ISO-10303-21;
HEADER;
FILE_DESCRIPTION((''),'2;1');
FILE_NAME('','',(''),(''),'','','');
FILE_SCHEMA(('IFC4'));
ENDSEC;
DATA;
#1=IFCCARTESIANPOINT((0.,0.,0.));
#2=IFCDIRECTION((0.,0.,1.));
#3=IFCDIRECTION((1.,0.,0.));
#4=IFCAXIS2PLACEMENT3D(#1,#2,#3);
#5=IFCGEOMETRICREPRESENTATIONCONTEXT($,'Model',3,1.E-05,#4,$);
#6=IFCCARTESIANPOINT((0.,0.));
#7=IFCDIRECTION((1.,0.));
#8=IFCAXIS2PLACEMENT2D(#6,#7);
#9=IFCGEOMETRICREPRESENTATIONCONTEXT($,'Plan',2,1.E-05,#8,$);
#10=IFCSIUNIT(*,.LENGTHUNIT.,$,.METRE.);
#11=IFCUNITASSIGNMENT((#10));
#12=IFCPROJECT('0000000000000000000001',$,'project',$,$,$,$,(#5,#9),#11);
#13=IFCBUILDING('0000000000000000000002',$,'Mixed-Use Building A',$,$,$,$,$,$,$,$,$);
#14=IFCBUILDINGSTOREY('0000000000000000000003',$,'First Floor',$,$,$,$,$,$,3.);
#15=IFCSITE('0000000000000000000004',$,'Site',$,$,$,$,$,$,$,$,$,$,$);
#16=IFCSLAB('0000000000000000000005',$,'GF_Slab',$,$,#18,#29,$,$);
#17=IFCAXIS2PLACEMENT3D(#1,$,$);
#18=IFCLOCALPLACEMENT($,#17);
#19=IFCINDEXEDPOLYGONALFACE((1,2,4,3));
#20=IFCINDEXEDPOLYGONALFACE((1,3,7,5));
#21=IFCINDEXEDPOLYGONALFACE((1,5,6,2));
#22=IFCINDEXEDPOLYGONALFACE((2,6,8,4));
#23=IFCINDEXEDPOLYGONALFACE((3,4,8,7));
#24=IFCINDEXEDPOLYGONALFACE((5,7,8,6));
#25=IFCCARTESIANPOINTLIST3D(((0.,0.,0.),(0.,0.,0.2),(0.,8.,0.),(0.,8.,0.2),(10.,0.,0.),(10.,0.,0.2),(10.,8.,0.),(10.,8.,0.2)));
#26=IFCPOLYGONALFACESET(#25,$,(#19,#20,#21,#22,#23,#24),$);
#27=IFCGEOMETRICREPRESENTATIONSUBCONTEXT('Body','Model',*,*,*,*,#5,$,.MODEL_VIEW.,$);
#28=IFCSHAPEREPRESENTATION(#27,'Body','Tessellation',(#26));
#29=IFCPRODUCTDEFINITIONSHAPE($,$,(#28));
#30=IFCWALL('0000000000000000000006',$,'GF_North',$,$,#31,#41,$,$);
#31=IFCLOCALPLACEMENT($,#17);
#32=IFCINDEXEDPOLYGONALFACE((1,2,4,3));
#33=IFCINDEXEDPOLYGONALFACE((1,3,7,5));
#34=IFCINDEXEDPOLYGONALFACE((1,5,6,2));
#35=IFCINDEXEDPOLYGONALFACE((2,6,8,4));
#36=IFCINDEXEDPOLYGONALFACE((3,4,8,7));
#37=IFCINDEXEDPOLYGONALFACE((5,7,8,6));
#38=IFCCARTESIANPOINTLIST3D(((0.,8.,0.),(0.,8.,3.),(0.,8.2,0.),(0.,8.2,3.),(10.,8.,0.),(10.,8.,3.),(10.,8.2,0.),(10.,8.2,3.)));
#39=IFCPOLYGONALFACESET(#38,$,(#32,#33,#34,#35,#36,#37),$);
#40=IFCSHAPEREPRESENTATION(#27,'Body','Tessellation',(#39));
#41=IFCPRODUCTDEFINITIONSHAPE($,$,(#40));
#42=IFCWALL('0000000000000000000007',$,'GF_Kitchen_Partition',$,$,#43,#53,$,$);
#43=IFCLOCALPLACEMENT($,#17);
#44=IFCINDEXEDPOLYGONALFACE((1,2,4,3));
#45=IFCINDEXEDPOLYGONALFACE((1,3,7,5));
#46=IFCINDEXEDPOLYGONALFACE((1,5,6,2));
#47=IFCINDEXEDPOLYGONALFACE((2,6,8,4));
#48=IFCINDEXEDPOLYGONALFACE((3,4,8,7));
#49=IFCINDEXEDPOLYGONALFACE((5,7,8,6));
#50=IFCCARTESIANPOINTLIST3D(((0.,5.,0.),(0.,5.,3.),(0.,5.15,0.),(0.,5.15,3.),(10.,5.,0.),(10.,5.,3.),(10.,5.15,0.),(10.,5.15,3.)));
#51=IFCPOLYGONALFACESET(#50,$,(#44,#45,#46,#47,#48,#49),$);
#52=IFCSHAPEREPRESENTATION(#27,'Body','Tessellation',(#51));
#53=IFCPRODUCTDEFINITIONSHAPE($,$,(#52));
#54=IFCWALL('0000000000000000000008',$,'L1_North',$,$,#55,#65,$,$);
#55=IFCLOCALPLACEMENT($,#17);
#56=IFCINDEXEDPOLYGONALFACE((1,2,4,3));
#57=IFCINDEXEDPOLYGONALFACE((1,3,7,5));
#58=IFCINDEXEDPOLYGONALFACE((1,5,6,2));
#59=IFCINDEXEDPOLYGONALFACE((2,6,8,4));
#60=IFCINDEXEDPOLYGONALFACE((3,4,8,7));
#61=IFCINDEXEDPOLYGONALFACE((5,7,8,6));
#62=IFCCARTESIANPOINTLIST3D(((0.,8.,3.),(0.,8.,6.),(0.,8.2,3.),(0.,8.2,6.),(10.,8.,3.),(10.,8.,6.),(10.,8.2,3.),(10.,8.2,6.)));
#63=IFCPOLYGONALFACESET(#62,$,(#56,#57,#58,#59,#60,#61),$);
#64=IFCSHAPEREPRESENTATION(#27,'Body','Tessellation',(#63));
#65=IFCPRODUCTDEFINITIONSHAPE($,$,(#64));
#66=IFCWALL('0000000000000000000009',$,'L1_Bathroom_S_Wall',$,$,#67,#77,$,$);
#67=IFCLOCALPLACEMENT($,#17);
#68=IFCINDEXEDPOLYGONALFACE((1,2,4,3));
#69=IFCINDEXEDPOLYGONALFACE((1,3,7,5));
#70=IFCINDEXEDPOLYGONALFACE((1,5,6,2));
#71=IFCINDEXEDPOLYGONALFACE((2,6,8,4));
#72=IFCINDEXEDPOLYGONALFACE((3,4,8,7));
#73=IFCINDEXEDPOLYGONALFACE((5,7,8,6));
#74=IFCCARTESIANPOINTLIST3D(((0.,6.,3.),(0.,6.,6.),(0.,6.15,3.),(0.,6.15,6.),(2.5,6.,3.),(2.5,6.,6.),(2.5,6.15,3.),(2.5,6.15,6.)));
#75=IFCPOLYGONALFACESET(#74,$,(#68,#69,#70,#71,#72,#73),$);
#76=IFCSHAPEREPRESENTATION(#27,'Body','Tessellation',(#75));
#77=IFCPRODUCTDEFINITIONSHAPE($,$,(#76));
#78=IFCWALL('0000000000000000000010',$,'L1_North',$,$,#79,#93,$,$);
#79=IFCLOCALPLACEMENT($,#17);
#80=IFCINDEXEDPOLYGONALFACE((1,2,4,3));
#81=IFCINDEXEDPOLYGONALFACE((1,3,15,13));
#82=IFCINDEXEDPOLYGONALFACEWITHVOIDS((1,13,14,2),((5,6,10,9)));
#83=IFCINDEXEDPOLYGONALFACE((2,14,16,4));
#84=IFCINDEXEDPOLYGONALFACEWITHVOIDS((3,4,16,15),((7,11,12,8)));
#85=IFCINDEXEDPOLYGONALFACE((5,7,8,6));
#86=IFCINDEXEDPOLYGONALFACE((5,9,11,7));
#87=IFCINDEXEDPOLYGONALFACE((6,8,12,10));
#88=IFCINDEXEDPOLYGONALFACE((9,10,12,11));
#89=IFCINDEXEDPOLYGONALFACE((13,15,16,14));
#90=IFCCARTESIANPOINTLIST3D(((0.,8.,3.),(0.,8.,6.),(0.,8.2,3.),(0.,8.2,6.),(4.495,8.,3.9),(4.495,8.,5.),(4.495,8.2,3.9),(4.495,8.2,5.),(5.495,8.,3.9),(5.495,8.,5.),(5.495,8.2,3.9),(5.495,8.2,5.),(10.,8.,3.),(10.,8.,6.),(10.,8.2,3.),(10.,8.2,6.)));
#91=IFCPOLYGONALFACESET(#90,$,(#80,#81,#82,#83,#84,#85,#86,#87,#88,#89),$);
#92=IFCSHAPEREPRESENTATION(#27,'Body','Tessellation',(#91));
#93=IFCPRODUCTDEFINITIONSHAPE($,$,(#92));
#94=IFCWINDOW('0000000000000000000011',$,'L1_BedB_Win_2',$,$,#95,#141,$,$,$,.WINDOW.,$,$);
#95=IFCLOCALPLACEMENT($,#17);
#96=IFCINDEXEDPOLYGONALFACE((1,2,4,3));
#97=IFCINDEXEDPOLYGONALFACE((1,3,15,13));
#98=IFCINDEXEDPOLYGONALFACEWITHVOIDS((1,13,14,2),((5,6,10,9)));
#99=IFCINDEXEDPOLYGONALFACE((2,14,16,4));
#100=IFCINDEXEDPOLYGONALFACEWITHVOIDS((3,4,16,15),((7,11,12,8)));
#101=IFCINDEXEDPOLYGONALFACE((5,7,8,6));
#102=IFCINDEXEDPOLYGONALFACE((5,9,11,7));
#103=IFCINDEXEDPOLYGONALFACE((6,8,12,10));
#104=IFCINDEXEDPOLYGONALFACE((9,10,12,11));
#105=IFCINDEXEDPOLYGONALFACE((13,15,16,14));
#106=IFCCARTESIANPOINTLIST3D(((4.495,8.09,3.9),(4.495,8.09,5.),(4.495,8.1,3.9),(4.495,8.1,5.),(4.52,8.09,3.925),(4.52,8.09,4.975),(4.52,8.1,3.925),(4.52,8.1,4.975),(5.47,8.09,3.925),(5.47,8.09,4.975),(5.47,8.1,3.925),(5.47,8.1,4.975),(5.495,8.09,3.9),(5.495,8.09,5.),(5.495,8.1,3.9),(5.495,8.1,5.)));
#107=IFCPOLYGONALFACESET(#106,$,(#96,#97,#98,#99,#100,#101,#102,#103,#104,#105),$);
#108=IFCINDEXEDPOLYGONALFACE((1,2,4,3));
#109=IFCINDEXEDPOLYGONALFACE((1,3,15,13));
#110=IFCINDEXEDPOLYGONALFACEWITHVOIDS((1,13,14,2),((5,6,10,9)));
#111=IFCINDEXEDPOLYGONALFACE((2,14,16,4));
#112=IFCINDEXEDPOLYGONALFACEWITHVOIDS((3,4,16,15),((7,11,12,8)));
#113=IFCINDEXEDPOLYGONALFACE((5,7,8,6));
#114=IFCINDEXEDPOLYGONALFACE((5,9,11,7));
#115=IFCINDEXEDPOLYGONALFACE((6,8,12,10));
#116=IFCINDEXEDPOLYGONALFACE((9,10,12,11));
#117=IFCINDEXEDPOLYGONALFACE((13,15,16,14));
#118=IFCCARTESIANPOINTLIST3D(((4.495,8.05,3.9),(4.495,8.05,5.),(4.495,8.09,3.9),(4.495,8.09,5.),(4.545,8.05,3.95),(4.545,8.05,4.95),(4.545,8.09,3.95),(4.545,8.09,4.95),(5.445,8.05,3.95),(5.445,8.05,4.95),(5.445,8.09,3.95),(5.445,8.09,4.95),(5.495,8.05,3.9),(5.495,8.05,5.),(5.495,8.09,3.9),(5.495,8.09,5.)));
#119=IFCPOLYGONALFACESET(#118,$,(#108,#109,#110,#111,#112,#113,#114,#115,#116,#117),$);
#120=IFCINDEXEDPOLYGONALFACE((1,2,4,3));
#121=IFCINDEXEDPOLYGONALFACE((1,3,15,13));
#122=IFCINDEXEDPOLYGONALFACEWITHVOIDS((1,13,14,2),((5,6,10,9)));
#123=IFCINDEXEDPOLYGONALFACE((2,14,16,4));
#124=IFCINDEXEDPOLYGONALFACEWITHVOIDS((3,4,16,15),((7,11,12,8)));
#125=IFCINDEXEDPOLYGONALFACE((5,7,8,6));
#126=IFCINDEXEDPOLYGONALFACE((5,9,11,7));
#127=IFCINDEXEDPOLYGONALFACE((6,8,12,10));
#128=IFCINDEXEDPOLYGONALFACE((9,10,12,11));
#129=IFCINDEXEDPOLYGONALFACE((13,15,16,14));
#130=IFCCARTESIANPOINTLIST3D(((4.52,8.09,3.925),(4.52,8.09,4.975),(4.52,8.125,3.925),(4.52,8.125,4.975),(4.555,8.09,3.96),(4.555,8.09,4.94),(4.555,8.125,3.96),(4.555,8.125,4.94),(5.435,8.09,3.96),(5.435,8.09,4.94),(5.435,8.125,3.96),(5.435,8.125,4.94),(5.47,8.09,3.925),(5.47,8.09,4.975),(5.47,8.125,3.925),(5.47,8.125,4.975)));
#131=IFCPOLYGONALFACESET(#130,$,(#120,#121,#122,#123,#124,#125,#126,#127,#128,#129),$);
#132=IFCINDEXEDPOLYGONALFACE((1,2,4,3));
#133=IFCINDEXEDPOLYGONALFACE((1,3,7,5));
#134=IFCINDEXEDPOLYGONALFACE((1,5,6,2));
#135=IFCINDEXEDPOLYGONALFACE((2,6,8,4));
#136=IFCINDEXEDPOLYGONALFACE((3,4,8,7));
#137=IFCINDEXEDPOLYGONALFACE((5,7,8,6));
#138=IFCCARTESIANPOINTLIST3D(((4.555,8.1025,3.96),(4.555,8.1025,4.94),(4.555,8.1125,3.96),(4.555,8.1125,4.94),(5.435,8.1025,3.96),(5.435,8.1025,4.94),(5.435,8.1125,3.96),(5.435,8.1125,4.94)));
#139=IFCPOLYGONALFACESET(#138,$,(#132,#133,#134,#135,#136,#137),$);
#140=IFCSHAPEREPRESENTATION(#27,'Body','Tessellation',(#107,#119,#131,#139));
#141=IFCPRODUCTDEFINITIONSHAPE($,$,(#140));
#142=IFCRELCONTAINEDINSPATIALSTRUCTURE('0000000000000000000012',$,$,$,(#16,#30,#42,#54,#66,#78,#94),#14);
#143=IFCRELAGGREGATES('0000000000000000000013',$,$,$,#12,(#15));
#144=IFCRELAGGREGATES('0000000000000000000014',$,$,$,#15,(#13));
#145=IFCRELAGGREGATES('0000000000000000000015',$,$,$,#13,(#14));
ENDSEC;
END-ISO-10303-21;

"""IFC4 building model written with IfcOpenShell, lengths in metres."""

from ifc_helpers import new_model, si_unit, frame, origin_with_axes, origin_2d_with_axis, place, context, subcontext, project, spatial, line, indexed_curve, outline, extrude, element, fill, save


model = new_model("IFC4")

# Units and contexts
model_context = context("Model", 3, precision=1e-05, world=origin_with_axes())
plan_context = context("Plan", 2, precision=1e-05, world=origin_2d_with_axis())
body_context = subcontext(model_context, "Body", "Model", "MODEL_VIEW")
ifc_project = project(units=[si_unit("LENGTHUNIT", "METRE")], contexts=[model_context, plan_context])

# Site, building, storey
site = spatial("IfcSite", under=ifc_project, Name="Site")
building = spatial("IfcBuilding", under=site, Name="Mixed-Use Building A")
storey = spatial("IfcBuildingStorey", under=building, Name="First Floor", Elevation=3.0)

# Slab
slab_placement = place(None, origin_with_axes())
element("IfcSlab", 1, at=slab_placement, inside=storey, Name="GF_Slab", context=body_context, shape_type="SweptSolid", body=[
    extrude(outline(indexed_curve([(0.0, 0.0), (10.0, 0.0), (10.0, 8.0), (0.0, 8.0)])), None, (0.0, 0.0, 1.0), 0.2),
])

# Walls
wall_1_placement = place(None, frame((0.0, 8.0, 0.0), z_axis=(0.0, 0.0, 1.0), x_axis=(1.0, 0.0, 0.0)))
element("IfcWall", 2, at=wall_1_placement, inside=storey, Name="GF_North", context=body_context, shape_type="SweptSolid", body=[
    extrude(outline(indexed_curve([(0.0, 0.0), (0.0, 0.2), (10.0, 0.2), (10.0, 0.0), (0.0, 0.0)], self_intersect=False)), origin_with_axes(), (0.0, 0.0, 1.0), 3.0),
])
wall_2_placement = place(None, frame((0.0, 5.0, 0.0), z_axis=(0.0, 0.0, 1.0), x_axis=(1.0, 0.0, 0.0)))
element("IfcWall", 3, at=wall_2_placement, inside=storey, Name="GF_Kitchen_Partition", context=body_context, shape_type="SweptSolid", body=[
    extrude(outline(indexed_curve([(0.0, 0.0), (0.0, 0.15), (10.0, 0.15), (10.0, 0.0), (0.0, 0.0)], self_intersect=False)), origin_with_axes(), (0.0, 0.0, 1.0), 3.0),
])
wall_3_placement = place(None, frame((0.0, 8.0, 3.0), z_axis=(0.0, 0.0, 1.0), x_axis=(1.0, 0.0, 0.0)))
element("IfcWall", 4, at=wall_3_placement, inside=storey, Name="L1_North", context=body_context, shape_type="SweptSolid", body=[
    extrude(outline(indexed_curve([(0.0, 0.0), (0.0, 0.2), (10.0, 0.2), (10.0, 0.0), (0.0, 0.0)], self_intersect=False)), origin_with_axes(), (0.0, 0.0, 1.0), 3.0),
])
wall_4_placement = place(None, frame((0.0, 6.0, 3.0), z_axis=(0.0, 0.0, 1.0), x_axis=(1.0, 0.0, 0.0)))
element("IfcWall", 5, at=wall_4_placement, inside=storey, Name="L1_Bathroom_S_Wall", context=body_context, shape_type="SweptSolid", body=[
    extrude(outline(indexed_curve([(0.0, 0.0), (0.0, 0.15), (2.5, 0.15), (2.5, 0.0), (0.0, 0.0)], self_intersect=False)), origin_with_axes(), (0.0, 0.0, 1.0), 3.0),
])

# Wall, opening, window
wall_5_placement = place(None, frame((0.0, 8.0, 3.0), z_axis=(0.0, 0.0, 1.0), x_axis=(1.0, 0.0, 0.0)))
wall_5 = element("IfcWall", 6, at=wall_5_placement, inside=storey, Name="L1_North", context=body_context, shape_type="SweptSolid", body=[
    extrude(outline(indexed_curve([(0.0, 0.0), (0.0, 0.2), (10.0, 0.2), (10.0, 0.0), (0.0, 0.0)], self_intersect=False)), origin_with_axes(), (0.0, 0.0, 1.0), 3.0),
])
opening_1_placement = place(wall_5_placement, frame((4.495, 0.0, 0.9), z_axis=(0.0, 0.0, 1.0), x_axis=(1.0, 0.0, 0.0)))
opening_1 = element("IfcOpeningElement", 7, at=opening_1_placement, inside=storey, cuts=wall_5, PredefinedType="OPENING", context=body_context, shape_type="SweptSolid", body=[
    extrude(outline(indexed_curve([(0.0, 0.0), (0.0, 0.3), (1.0, 0.3), (1.0, 0.0), (0.0, 0.0)], self_intersect=False)), origin_with_axes(), (0.0, 0.0, 1.0), 1.1),
])
window_1_placement = place(None, frame((4.495, 8.0, 3.9), z_axis=(0.0, 0.0, 1.0), x_axis=(1.0, 0.0, 0.0)))
window_1 = element("IfcWindow", 8, at=window_1_placement, inside=storey, Name="L1_BedB_Win_2", PredefinedType="WINDOW", context=body_context, shape_type="SweptSolid", body=[
    extrude(outline(indexed_curve([(0.0, 0.0), (1.0, 0.0), (1.0, 1.1), (0.0, 1.1)], segments=[line(1, 2, 3, 4, 1)]), holes=[indexed_curve([(0.025, 0.025), (0.975, 0.025), (0.975, 1.075), (0.025, 1.075)], segments=[line(1, 2, 3, 4, 1)])]), frame((0.0, 0.09, 0.0), z_axis=(0.0, -1.0, 0.0), x_axis=(1.0, 0.0, 0.0)), (0.0, 0.0, -1.0), 0.01),
    extrude(outline(indexed_curve([(0.0, 0.0), (1.0, 0.0), (1.0, 1.1), (0.0, 1.1)], segments=[line(1, 2, 3, 4, 1)]), holes=[indexed_curve([(0.05, 0.05), (0.95, 0.05), (0.95, 1.05), (0.05, 1.05)], segments=[line(1, 2, 3, 4, 1)])]), frame((0.0, 0.05, 0.0), z_axis=(0.0, -1.0, 0.0), x_axis=(1.0, 0.0, 0.0)), (0.0, 0.0, -1.0), 0.04),
    extrude(outline(indexed_curve([(0.0, 0.0), (0.95, 0.0), (0.95, 1.05), (0.0, 1.05)], segments=[line(1, 2, 3, 4, 1)]), holes=[indexed_curve([(0.035, 0.035), (0.915, 0.035), (0.915, 1.015), (0.035, 1.015)], segments=[line(1, 2, 3, 4, 1)])]), frame((0.025, 0.09, 0.025), z_axis=(0.0, -1.0, 0.0), x_axis=(1.0, 0.0, 0.0)), (0.0, 0.0, -1.0), 0.035),
    extrude(outline(indexed_curve([(0.035, 0.035), (0.915, 0.035), (0.915, 1.015), (0.035, 1.015)], segments=[line(1, 2, 3, 4, 1)])), frame((0.025, 0.1025, 0.025), z_axis=(0.0, -1.0, 0.0), x_axis=(1.0, 0.0, 0.0)), (0.0, 0.0, -1.0), 0.01),
])
fill(opening_1, window_1)

save(model, "model.ifc")
